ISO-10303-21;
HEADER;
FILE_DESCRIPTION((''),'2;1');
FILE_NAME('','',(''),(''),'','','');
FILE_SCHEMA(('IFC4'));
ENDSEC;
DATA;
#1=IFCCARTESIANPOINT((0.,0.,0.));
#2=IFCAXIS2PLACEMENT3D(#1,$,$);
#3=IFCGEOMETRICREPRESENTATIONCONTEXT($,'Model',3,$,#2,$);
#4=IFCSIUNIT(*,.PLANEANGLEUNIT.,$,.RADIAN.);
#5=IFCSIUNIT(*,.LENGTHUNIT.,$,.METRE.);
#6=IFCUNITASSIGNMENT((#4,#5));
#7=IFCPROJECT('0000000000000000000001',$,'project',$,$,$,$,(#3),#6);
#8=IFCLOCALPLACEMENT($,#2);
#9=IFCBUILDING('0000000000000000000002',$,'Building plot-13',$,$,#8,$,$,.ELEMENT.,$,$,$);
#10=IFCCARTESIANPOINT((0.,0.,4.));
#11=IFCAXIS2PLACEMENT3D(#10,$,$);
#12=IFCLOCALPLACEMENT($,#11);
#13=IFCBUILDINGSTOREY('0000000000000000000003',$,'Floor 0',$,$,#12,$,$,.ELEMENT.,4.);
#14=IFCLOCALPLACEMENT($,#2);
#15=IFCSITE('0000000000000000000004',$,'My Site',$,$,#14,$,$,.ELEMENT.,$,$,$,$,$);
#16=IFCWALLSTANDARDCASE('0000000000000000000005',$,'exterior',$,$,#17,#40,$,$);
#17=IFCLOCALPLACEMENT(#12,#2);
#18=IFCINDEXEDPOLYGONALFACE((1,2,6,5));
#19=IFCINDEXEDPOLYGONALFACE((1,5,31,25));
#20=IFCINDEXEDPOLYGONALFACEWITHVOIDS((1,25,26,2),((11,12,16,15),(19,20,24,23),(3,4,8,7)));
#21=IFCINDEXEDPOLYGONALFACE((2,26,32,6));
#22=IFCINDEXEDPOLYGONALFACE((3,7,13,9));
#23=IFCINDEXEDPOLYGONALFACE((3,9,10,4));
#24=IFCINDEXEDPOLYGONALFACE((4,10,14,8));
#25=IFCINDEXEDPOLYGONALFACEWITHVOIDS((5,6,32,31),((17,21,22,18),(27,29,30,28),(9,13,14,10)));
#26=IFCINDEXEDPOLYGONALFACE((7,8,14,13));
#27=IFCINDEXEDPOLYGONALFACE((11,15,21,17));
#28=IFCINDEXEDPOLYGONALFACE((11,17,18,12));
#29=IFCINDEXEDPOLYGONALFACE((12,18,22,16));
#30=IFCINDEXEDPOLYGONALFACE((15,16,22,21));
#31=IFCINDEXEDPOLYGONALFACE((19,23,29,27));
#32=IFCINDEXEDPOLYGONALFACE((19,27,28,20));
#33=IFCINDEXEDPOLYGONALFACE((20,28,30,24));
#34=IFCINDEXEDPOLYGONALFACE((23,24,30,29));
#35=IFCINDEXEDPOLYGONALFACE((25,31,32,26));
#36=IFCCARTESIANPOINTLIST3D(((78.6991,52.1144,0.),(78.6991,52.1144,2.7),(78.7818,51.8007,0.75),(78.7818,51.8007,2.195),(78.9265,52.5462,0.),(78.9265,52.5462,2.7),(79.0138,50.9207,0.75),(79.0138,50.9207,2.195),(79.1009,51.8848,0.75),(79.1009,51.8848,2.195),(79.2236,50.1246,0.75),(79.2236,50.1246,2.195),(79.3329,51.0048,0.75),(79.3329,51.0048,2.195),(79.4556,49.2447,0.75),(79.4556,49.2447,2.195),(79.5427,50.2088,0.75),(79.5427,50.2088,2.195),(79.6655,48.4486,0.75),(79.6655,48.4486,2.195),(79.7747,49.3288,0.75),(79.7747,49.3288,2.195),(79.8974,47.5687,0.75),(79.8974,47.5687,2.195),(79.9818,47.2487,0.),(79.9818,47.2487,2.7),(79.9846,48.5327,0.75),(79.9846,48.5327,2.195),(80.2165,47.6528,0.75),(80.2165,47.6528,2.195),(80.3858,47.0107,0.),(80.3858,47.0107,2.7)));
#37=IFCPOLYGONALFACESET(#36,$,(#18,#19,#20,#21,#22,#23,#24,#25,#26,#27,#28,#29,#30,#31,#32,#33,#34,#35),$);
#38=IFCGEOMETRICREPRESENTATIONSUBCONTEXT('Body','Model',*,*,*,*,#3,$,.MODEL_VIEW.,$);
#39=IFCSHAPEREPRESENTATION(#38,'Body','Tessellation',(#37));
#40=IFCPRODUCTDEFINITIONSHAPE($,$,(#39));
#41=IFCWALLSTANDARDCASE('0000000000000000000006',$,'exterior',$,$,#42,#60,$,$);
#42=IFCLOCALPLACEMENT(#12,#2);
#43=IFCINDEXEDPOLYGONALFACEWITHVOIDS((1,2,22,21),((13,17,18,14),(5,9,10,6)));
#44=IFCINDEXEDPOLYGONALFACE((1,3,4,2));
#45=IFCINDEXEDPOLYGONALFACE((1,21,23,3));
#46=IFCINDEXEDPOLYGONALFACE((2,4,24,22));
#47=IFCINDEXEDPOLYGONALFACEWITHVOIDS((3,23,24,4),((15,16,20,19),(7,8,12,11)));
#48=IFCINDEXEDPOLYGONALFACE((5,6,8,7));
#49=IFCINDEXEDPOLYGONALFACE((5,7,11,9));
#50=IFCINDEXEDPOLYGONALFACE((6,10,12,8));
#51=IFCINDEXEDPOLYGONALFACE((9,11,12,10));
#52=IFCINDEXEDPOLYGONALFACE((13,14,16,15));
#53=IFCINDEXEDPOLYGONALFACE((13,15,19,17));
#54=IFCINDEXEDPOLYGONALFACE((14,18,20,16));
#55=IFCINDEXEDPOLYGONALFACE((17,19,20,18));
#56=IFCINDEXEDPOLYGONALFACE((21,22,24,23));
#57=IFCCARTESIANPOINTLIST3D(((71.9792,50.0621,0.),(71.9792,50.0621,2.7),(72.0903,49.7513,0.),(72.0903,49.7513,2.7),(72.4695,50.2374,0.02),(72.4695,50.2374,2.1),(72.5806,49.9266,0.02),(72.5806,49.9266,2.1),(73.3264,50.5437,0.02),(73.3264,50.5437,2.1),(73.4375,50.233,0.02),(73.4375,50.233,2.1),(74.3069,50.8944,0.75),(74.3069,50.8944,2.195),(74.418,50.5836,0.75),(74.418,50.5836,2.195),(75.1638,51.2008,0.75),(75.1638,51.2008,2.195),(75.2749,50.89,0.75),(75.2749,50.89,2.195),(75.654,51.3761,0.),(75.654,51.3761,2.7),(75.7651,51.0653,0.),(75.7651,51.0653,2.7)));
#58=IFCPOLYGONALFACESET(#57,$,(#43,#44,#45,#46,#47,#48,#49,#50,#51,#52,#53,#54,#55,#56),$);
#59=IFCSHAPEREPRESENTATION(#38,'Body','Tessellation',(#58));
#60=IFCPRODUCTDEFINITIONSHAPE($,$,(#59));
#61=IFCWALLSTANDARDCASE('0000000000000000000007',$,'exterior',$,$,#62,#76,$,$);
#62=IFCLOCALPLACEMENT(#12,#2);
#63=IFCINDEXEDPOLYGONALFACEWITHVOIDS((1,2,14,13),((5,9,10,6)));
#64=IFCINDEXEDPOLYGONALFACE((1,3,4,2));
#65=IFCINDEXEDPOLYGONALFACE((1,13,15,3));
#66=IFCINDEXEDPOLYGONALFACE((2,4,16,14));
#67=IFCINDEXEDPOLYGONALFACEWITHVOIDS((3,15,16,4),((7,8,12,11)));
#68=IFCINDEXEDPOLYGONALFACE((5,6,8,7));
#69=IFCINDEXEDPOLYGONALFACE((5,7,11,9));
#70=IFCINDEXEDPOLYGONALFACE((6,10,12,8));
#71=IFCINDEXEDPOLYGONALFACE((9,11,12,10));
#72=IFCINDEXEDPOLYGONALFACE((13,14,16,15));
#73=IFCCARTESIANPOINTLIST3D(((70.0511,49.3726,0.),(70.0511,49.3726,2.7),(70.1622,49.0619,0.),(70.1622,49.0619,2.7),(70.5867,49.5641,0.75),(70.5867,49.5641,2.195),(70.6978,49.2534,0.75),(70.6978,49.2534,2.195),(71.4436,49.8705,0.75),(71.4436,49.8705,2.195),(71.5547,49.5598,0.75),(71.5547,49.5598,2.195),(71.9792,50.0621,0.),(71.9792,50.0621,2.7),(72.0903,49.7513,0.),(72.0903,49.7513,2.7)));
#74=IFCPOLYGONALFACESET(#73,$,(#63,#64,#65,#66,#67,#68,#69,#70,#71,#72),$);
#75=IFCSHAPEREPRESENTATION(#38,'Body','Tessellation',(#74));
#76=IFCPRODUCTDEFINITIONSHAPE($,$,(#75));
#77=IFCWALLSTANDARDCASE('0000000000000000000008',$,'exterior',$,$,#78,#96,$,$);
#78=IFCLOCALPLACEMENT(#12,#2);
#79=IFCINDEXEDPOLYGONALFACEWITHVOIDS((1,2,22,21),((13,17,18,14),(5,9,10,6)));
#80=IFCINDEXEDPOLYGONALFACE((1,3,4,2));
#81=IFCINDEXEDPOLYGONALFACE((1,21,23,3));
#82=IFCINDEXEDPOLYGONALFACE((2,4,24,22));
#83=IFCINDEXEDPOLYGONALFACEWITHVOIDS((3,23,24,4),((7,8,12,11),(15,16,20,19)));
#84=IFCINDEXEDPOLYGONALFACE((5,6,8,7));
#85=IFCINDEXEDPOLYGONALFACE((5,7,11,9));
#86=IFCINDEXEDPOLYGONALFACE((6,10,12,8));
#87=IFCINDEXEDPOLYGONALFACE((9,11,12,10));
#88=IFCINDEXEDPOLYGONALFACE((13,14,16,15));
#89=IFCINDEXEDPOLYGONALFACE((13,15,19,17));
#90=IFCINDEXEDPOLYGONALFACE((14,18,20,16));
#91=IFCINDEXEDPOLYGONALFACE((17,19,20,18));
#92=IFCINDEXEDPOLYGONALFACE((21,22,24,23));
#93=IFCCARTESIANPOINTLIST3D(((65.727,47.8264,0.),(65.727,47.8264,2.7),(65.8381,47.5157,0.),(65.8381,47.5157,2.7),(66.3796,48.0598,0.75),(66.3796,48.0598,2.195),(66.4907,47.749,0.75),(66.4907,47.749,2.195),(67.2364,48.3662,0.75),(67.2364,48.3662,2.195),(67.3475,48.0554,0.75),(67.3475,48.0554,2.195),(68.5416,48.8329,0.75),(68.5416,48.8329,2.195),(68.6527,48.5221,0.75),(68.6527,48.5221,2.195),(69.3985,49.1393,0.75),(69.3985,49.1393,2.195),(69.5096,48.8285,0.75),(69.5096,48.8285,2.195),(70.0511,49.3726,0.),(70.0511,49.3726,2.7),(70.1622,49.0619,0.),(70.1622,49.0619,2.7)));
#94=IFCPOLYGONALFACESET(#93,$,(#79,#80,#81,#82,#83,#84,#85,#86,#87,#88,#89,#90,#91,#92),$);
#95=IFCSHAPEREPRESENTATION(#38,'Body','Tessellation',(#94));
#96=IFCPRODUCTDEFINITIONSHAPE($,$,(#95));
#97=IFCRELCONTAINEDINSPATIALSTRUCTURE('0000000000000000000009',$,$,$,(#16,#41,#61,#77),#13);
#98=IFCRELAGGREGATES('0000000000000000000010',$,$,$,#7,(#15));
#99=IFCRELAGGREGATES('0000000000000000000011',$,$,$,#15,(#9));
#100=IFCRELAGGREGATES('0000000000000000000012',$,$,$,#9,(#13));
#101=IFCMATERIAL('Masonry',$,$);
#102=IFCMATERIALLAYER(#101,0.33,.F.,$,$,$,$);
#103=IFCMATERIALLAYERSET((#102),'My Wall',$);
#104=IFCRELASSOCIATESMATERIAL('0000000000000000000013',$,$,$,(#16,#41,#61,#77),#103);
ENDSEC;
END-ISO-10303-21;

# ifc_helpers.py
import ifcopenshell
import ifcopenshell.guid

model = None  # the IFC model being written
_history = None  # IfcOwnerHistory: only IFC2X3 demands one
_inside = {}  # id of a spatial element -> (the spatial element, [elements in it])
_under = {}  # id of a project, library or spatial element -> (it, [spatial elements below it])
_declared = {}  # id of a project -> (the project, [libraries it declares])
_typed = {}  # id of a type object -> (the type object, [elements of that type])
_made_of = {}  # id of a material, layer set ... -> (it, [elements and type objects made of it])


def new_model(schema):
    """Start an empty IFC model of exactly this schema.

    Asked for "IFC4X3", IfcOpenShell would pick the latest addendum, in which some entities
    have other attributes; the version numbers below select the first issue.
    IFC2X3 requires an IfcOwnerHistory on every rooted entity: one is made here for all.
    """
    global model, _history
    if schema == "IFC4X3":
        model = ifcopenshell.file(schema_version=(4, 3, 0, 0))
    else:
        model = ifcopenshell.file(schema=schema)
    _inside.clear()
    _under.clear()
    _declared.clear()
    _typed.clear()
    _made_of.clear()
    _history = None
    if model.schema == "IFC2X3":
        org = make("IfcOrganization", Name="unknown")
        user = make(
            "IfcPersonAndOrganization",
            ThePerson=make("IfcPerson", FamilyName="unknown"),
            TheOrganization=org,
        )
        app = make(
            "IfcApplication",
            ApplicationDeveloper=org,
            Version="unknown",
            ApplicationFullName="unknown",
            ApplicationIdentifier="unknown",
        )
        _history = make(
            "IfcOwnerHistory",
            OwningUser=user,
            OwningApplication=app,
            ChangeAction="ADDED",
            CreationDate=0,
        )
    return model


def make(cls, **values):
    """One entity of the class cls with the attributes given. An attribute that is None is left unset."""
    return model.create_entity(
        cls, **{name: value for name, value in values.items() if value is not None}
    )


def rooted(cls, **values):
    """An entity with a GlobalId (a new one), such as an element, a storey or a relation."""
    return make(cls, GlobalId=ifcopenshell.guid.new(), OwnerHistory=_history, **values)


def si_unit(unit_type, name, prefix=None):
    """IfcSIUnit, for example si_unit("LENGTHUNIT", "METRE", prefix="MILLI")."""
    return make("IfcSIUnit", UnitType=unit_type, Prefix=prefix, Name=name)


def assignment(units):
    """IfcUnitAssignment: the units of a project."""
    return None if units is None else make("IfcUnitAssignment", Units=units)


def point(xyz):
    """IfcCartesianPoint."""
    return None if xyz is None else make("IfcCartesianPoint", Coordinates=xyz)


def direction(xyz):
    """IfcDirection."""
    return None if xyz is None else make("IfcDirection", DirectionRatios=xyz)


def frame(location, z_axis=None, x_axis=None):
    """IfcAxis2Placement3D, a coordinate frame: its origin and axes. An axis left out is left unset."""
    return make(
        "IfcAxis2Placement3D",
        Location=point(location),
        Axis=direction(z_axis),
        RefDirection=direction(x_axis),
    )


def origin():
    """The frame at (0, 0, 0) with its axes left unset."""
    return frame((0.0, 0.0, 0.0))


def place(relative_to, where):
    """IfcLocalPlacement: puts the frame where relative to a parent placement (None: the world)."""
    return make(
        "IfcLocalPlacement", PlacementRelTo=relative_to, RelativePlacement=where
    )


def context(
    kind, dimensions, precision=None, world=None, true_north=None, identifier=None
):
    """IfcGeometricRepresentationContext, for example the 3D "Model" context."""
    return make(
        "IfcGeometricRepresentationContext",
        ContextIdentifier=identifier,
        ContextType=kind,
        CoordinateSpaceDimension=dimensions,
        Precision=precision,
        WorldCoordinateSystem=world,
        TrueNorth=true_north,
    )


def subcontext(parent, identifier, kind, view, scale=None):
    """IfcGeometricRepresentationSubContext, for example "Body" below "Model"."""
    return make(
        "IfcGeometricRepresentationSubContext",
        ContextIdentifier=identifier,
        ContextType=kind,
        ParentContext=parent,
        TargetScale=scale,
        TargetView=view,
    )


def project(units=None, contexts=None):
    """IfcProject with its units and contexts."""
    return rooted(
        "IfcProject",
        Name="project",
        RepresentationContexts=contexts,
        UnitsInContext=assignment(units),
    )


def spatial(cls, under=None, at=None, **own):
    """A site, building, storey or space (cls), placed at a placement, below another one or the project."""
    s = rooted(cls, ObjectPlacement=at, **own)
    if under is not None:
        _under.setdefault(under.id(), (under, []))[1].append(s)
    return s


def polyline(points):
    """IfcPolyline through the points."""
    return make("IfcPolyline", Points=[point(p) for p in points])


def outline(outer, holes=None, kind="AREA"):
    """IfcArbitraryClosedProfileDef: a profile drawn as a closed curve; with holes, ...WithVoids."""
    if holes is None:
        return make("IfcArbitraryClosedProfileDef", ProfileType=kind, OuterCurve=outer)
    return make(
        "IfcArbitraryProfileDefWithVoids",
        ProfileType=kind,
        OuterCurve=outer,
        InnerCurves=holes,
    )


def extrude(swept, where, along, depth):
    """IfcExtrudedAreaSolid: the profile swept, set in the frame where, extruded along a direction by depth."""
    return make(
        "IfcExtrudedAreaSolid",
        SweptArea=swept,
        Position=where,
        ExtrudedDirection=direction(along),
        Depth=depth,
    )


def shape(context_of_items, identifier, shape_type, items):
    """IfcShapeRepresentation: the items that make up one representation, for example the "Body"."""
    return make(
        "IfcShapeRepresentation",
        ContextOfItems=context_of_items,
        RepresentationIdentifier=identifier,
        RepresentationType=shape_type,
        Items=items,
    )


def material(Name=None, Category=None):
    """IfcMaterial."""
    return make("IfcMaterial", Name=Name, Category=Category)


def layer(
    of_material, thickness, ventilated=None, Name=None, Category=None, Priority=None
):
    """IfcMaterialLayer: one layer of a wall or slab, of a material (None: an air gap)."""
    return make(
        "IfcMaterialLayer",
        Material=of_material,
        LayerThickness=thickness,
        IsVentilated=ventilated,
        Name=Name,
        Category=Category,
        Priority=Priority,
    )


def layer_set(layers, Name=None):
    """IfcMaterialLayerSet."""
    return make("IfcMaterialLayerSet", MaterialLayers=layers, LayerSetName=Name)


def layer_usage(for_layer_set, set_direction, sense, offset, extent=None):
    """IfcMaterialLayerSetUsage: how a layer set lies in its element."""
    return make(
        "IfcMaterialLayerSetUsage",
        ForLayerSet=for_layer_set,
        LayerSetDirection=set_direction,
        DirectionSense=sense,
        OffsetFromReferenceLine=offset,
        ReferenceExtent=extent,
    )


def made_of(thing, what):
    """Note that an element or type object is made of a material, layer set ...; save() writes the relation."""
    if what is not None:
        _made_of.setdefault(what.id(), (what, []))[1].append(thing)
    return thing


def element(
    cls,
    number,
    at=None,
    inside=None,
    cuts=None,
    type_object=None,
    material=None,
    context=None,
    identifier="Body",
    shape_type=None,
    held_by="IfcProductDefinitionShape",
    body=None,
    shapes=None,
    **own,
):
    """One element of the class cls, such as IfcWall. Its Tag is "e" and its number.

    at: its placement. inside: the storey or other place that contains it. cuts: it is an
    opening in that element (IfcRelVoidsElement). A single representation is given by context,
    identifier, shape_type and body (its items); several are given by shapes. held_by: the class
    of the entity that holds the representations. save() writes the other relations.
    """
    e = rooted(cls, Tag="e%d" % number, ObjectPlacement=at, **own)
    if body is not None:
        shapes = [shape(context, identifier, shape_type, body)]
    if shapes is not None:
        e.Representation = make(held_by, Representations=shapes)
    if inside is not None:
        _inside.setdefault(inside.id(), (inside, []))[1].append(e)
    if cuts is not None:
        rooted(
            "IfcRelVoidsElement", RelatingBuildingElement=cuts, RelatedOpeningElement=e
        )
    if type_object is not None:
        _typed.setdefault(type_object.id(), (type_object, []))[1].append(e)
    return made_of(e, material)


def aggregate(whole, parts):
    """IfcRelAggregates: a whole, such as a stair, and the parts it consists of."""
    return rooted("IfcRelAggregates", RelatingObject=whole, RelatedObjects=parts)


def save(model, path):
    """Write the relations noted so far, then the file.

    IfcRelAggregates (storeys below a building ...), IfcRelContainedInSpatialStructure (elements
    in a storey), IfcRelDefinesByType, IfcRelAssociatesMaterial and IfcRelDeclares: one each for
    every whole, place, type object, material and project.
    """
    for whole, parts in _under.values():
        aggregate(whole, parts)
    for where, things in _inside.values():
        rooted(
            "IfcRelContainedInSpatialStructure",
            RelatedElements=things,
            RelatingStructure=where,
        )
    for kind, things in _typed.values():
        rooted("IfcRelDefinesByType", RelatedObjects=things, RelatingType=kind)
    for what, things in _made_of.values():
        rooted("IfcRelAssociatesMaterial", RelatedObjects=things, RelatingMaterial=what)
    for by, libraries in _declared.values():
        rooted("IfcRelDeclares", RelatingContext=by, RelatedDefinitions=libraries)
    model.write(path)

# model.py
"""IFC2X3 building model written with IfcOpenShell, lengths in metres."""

from ifc_helpers import new_model, si_unit, frame, origin, place, context, subcontext, project, spatial, polyline, outline, extrude, material, layer, layer_set, layer_usage, element, save


model = new_model("IFC2X3")

# Units and contexts
model_context = context("Model", 3, world=origin())
body_context = subcontext(model_context, "Body", "Model", "MODEL_VIEW")
ifc_project = project(units=[si_unit("PLANEANGLEUNIT", "RADIAN"), si_unit("LENGTHUNIT", "METRE")], contexts=[model_context])

# Site, building, storey
site_placement = place(None, origin())
site = spatial("IfcSite", under=ifc_project, at=site_placement, Name="My Site", CompositionType="ELEMENT")
building_placement = place(None, origin())
building = spatial("IfcBuilding", under=site, at=building_placement, Name="Building plot-13", CompositionType="ELEMENT")
storey_placement = place(None, frame((0.0, 0.0, 4.0)))
storey = spatial("IfcBuildingStorey", under=building, at=storey_placement, Name="Floor 0", CompositionType="ELEMENT", Elevation=4.0)

# Shared definitions
ifc_material = material(Name="Masonry")
ifc_layer = layer(ifc_material, 0.33, ventilated=False)
ifc_layer_set = layer_set([ifc_layer], Name="My Wall")
ifc_layer_usage = layer_usage(ifc_layer_set, "AXIS2", "NEGATIVE", 0.08)

# Wall, openings
wall_1_placement = place(storey_placement, origin())
wall_1 = element("IfcWallStandardCase", 1, at=wall_1_placement, inside=storey, material=ifc_layer_usage, Name="exterior", context=body_context, shape_type="SweptSolid", body=[
    extrude(outline(polyline([(79.9818, 47.2487), (80.3858, 47.0107), (78.9265, 52.5462), (78.6991, 52.1144), (79.9818, 47.2487)])), origin(), (0.0, 0.0, 1.0), 2.7),
])
opening_1_placement = place(storey_placement, frame((0.0, 0.0, 0.75)))
element("IfcOpeningElement", 2, at=opening_1_placement, cuts=wall_1, ObjectType="Opening", context=body_context, shape_type="SweptSolid", body=[
    extrude(outline(polyline([(80.2165, 47.6528), (79.9846, 48.5327), (79.6655, 48.4486), (79.8974, 47.5687), (80.2165, 47.6528)])), origin(), (0.0, 0.0, 1.0), 1.445),
])
opening_2_placement = place(storey_placement, frame((0.0, 0.0, 0.75)))
element("IfcOpeningElement", 3, at=opening_2_placement, cuts=wall_1, ObjectType="Opening", context=body_context, shape_type="SweptSolid", body=[
    extrude(outline(polyline([(79.7747, 49.3288), (79.5427, 50.2088), (79.2236, 50.1246), (79.4556, 49.2447), (79.7747, 49.3288)])), origin(), (0.0, 0.0, 1.0), 1.445),
])
opening_3_placement = place(storey_placement, frame((0.0, 0.0, 0.75)))
element("IfcOpeningElement", 4, at=opening_3_placement, cuts=wall_1, ObjectType="Opening", context=body_context, shape_type="SweptSolid", body=[
    extrude(outline(polyline([(79.3329, 51.0048), (79.1009, 51.8848), (78.7818, 51.8007), (79.0138, 50.9207), (79.3329, 51.0048)])), origin(), (0.0, 0.0, 1.0), 1.445),
])

# Wall, openings
wall_2_placement = place(storey_placement, origin())
wall_2 = element("IfcWallStandardCase", 5, at=wall_2_placement, inside=storey, material=ifc_layer_usage, Name="exterior", context=body_context, shape_type="SweptSolid", body=[
    extrude(outline(polyline([(75.7651, 51.0653), (75.654, 51.3761), (71.9792, 50.0621), (72.0903, 49.7513), (75.7651, 51.0653)])), origin(), (0.0, 0.0, 1.0), 2.7),
])
opening_4_placement = place(storey_placement, frame((0.0, 0.0, 0.75)))
element("IfcOpeningElement", 6, at=opening_4_placement, cuts=wall_2, ObjectType="Opening", context=body_context, shape_type="SweptSolid", body=[
    extrude(outline(polyline([(75.1638, 51.2008), (74.3069, 50.8944), (74.418, 50.5836), (75.2749, 50.89), (75.1638, 51.2008)])), origin(), (0.0, 0.0, 1.0), 1.445),
])
opening_5_placement = place(storey_placement, frame((0.0, 0.0, 0.02)))
element("IfcOpeningElement", 7, at=opening_5_placement, cuts=wall_2, ObjectType="Opening", context=body_context, shape_type="SweptSolid", body=[
    extrude(outline(polyline([(73.3264, 50.5437), (72.4695, 50.2374), (72.5806, 49.9266), (73.4375, 50.233), (73.3264, 50.5437)])), origin(), (0.0, 0.0, 1.0), 2.08),
])

# Wall, opening
wall_3_placement = place(storey_placement, origin())
wall_3 = element("IfcWallStandardCase", 8, at=wall_3_placement, inside=storey, material=ifc_layer_usage, Name="exterior", context=body_context, shape_type="SweptSolid", body=[
    extrude(outline(polyline([(72.0903, 49.7513), (71.9792, 50.0621), (70.0511, 49.3726), (70.1622, 49.0619), (72.0903, 49.7513)])), origin(), (0.0, 0.0, 1.0), 2.7),
])
opening_6_placement = place(storey_placement, frame((0.0, 0.0, 0.75)))
element("IfcOpeningElement", 9, at=opening_6_placement, cuts=wall_3, ObjectType="Opening", context=body_context, shape_type="SweptSolid", body=[
    extrude(outline(polyline([(71.4436, 49.8705), (70.5867, 49.5641), (70.6978, 49.2534), (71.5547, 49.5598), (71.4436, 49.8705)])), origin(), (0.0, 0.0, 1.0), 1.445),
])

# Wall, openings
wall_4_placement = place(storey_placement, origin())
wall_4 = element("IfcWallStandardCase", 10, at=wall_4_placement, inside=storey, material=ifc_layer_usage, Name="exterior", context=body_context, shape_type="SweptSolid", body=[
    extrude(outline(polyline([(70.1622, 49.0619), (70.0511, 49.3726), (65.727, 47.8264), (65.8381, 47.5157), (70.1622, 49.0619)])), origin(), (0.0, 0.0, 1.0), 2.7),
])
opening_7_placement = place(storey_placement, frame((0.0, 0.0, 0.75)))
element("IfcOpeningElement", 11, at=opening_7_placement, cuts=wall_4, ObjectType="Opening", context=body_context, shape_type="SweptSolid", body=[
    extrude(outline(polyline([(69.3985, 49.1393), (68.5416, 48.8329), (68.6527, 48.5221), (69.5096, 48.8285), (69.3985, 49.1393)])), origin(), (0.0, 0.0, 1.0), 1.445),
])
opening_8_placement = place(storey_placement, frame((0.0, 0.0, 0.75)))
element("IfcOpeningElement", 12, at=opening_8_placement, cuts=wall_4, ObjectType="Opening", context=body_context, shape_type="SweptSolid", body=[
    extrude(outline(polyline([(67.2364, 48.3662), (66.3796, 48.0598), (66.4907, 47.749), (67.3475, 48.0554), (67.2364, 48.3662)])), origin(), (0.0, 0.0, 1.0), 1.445),
])

save(model, "model.ifc")
